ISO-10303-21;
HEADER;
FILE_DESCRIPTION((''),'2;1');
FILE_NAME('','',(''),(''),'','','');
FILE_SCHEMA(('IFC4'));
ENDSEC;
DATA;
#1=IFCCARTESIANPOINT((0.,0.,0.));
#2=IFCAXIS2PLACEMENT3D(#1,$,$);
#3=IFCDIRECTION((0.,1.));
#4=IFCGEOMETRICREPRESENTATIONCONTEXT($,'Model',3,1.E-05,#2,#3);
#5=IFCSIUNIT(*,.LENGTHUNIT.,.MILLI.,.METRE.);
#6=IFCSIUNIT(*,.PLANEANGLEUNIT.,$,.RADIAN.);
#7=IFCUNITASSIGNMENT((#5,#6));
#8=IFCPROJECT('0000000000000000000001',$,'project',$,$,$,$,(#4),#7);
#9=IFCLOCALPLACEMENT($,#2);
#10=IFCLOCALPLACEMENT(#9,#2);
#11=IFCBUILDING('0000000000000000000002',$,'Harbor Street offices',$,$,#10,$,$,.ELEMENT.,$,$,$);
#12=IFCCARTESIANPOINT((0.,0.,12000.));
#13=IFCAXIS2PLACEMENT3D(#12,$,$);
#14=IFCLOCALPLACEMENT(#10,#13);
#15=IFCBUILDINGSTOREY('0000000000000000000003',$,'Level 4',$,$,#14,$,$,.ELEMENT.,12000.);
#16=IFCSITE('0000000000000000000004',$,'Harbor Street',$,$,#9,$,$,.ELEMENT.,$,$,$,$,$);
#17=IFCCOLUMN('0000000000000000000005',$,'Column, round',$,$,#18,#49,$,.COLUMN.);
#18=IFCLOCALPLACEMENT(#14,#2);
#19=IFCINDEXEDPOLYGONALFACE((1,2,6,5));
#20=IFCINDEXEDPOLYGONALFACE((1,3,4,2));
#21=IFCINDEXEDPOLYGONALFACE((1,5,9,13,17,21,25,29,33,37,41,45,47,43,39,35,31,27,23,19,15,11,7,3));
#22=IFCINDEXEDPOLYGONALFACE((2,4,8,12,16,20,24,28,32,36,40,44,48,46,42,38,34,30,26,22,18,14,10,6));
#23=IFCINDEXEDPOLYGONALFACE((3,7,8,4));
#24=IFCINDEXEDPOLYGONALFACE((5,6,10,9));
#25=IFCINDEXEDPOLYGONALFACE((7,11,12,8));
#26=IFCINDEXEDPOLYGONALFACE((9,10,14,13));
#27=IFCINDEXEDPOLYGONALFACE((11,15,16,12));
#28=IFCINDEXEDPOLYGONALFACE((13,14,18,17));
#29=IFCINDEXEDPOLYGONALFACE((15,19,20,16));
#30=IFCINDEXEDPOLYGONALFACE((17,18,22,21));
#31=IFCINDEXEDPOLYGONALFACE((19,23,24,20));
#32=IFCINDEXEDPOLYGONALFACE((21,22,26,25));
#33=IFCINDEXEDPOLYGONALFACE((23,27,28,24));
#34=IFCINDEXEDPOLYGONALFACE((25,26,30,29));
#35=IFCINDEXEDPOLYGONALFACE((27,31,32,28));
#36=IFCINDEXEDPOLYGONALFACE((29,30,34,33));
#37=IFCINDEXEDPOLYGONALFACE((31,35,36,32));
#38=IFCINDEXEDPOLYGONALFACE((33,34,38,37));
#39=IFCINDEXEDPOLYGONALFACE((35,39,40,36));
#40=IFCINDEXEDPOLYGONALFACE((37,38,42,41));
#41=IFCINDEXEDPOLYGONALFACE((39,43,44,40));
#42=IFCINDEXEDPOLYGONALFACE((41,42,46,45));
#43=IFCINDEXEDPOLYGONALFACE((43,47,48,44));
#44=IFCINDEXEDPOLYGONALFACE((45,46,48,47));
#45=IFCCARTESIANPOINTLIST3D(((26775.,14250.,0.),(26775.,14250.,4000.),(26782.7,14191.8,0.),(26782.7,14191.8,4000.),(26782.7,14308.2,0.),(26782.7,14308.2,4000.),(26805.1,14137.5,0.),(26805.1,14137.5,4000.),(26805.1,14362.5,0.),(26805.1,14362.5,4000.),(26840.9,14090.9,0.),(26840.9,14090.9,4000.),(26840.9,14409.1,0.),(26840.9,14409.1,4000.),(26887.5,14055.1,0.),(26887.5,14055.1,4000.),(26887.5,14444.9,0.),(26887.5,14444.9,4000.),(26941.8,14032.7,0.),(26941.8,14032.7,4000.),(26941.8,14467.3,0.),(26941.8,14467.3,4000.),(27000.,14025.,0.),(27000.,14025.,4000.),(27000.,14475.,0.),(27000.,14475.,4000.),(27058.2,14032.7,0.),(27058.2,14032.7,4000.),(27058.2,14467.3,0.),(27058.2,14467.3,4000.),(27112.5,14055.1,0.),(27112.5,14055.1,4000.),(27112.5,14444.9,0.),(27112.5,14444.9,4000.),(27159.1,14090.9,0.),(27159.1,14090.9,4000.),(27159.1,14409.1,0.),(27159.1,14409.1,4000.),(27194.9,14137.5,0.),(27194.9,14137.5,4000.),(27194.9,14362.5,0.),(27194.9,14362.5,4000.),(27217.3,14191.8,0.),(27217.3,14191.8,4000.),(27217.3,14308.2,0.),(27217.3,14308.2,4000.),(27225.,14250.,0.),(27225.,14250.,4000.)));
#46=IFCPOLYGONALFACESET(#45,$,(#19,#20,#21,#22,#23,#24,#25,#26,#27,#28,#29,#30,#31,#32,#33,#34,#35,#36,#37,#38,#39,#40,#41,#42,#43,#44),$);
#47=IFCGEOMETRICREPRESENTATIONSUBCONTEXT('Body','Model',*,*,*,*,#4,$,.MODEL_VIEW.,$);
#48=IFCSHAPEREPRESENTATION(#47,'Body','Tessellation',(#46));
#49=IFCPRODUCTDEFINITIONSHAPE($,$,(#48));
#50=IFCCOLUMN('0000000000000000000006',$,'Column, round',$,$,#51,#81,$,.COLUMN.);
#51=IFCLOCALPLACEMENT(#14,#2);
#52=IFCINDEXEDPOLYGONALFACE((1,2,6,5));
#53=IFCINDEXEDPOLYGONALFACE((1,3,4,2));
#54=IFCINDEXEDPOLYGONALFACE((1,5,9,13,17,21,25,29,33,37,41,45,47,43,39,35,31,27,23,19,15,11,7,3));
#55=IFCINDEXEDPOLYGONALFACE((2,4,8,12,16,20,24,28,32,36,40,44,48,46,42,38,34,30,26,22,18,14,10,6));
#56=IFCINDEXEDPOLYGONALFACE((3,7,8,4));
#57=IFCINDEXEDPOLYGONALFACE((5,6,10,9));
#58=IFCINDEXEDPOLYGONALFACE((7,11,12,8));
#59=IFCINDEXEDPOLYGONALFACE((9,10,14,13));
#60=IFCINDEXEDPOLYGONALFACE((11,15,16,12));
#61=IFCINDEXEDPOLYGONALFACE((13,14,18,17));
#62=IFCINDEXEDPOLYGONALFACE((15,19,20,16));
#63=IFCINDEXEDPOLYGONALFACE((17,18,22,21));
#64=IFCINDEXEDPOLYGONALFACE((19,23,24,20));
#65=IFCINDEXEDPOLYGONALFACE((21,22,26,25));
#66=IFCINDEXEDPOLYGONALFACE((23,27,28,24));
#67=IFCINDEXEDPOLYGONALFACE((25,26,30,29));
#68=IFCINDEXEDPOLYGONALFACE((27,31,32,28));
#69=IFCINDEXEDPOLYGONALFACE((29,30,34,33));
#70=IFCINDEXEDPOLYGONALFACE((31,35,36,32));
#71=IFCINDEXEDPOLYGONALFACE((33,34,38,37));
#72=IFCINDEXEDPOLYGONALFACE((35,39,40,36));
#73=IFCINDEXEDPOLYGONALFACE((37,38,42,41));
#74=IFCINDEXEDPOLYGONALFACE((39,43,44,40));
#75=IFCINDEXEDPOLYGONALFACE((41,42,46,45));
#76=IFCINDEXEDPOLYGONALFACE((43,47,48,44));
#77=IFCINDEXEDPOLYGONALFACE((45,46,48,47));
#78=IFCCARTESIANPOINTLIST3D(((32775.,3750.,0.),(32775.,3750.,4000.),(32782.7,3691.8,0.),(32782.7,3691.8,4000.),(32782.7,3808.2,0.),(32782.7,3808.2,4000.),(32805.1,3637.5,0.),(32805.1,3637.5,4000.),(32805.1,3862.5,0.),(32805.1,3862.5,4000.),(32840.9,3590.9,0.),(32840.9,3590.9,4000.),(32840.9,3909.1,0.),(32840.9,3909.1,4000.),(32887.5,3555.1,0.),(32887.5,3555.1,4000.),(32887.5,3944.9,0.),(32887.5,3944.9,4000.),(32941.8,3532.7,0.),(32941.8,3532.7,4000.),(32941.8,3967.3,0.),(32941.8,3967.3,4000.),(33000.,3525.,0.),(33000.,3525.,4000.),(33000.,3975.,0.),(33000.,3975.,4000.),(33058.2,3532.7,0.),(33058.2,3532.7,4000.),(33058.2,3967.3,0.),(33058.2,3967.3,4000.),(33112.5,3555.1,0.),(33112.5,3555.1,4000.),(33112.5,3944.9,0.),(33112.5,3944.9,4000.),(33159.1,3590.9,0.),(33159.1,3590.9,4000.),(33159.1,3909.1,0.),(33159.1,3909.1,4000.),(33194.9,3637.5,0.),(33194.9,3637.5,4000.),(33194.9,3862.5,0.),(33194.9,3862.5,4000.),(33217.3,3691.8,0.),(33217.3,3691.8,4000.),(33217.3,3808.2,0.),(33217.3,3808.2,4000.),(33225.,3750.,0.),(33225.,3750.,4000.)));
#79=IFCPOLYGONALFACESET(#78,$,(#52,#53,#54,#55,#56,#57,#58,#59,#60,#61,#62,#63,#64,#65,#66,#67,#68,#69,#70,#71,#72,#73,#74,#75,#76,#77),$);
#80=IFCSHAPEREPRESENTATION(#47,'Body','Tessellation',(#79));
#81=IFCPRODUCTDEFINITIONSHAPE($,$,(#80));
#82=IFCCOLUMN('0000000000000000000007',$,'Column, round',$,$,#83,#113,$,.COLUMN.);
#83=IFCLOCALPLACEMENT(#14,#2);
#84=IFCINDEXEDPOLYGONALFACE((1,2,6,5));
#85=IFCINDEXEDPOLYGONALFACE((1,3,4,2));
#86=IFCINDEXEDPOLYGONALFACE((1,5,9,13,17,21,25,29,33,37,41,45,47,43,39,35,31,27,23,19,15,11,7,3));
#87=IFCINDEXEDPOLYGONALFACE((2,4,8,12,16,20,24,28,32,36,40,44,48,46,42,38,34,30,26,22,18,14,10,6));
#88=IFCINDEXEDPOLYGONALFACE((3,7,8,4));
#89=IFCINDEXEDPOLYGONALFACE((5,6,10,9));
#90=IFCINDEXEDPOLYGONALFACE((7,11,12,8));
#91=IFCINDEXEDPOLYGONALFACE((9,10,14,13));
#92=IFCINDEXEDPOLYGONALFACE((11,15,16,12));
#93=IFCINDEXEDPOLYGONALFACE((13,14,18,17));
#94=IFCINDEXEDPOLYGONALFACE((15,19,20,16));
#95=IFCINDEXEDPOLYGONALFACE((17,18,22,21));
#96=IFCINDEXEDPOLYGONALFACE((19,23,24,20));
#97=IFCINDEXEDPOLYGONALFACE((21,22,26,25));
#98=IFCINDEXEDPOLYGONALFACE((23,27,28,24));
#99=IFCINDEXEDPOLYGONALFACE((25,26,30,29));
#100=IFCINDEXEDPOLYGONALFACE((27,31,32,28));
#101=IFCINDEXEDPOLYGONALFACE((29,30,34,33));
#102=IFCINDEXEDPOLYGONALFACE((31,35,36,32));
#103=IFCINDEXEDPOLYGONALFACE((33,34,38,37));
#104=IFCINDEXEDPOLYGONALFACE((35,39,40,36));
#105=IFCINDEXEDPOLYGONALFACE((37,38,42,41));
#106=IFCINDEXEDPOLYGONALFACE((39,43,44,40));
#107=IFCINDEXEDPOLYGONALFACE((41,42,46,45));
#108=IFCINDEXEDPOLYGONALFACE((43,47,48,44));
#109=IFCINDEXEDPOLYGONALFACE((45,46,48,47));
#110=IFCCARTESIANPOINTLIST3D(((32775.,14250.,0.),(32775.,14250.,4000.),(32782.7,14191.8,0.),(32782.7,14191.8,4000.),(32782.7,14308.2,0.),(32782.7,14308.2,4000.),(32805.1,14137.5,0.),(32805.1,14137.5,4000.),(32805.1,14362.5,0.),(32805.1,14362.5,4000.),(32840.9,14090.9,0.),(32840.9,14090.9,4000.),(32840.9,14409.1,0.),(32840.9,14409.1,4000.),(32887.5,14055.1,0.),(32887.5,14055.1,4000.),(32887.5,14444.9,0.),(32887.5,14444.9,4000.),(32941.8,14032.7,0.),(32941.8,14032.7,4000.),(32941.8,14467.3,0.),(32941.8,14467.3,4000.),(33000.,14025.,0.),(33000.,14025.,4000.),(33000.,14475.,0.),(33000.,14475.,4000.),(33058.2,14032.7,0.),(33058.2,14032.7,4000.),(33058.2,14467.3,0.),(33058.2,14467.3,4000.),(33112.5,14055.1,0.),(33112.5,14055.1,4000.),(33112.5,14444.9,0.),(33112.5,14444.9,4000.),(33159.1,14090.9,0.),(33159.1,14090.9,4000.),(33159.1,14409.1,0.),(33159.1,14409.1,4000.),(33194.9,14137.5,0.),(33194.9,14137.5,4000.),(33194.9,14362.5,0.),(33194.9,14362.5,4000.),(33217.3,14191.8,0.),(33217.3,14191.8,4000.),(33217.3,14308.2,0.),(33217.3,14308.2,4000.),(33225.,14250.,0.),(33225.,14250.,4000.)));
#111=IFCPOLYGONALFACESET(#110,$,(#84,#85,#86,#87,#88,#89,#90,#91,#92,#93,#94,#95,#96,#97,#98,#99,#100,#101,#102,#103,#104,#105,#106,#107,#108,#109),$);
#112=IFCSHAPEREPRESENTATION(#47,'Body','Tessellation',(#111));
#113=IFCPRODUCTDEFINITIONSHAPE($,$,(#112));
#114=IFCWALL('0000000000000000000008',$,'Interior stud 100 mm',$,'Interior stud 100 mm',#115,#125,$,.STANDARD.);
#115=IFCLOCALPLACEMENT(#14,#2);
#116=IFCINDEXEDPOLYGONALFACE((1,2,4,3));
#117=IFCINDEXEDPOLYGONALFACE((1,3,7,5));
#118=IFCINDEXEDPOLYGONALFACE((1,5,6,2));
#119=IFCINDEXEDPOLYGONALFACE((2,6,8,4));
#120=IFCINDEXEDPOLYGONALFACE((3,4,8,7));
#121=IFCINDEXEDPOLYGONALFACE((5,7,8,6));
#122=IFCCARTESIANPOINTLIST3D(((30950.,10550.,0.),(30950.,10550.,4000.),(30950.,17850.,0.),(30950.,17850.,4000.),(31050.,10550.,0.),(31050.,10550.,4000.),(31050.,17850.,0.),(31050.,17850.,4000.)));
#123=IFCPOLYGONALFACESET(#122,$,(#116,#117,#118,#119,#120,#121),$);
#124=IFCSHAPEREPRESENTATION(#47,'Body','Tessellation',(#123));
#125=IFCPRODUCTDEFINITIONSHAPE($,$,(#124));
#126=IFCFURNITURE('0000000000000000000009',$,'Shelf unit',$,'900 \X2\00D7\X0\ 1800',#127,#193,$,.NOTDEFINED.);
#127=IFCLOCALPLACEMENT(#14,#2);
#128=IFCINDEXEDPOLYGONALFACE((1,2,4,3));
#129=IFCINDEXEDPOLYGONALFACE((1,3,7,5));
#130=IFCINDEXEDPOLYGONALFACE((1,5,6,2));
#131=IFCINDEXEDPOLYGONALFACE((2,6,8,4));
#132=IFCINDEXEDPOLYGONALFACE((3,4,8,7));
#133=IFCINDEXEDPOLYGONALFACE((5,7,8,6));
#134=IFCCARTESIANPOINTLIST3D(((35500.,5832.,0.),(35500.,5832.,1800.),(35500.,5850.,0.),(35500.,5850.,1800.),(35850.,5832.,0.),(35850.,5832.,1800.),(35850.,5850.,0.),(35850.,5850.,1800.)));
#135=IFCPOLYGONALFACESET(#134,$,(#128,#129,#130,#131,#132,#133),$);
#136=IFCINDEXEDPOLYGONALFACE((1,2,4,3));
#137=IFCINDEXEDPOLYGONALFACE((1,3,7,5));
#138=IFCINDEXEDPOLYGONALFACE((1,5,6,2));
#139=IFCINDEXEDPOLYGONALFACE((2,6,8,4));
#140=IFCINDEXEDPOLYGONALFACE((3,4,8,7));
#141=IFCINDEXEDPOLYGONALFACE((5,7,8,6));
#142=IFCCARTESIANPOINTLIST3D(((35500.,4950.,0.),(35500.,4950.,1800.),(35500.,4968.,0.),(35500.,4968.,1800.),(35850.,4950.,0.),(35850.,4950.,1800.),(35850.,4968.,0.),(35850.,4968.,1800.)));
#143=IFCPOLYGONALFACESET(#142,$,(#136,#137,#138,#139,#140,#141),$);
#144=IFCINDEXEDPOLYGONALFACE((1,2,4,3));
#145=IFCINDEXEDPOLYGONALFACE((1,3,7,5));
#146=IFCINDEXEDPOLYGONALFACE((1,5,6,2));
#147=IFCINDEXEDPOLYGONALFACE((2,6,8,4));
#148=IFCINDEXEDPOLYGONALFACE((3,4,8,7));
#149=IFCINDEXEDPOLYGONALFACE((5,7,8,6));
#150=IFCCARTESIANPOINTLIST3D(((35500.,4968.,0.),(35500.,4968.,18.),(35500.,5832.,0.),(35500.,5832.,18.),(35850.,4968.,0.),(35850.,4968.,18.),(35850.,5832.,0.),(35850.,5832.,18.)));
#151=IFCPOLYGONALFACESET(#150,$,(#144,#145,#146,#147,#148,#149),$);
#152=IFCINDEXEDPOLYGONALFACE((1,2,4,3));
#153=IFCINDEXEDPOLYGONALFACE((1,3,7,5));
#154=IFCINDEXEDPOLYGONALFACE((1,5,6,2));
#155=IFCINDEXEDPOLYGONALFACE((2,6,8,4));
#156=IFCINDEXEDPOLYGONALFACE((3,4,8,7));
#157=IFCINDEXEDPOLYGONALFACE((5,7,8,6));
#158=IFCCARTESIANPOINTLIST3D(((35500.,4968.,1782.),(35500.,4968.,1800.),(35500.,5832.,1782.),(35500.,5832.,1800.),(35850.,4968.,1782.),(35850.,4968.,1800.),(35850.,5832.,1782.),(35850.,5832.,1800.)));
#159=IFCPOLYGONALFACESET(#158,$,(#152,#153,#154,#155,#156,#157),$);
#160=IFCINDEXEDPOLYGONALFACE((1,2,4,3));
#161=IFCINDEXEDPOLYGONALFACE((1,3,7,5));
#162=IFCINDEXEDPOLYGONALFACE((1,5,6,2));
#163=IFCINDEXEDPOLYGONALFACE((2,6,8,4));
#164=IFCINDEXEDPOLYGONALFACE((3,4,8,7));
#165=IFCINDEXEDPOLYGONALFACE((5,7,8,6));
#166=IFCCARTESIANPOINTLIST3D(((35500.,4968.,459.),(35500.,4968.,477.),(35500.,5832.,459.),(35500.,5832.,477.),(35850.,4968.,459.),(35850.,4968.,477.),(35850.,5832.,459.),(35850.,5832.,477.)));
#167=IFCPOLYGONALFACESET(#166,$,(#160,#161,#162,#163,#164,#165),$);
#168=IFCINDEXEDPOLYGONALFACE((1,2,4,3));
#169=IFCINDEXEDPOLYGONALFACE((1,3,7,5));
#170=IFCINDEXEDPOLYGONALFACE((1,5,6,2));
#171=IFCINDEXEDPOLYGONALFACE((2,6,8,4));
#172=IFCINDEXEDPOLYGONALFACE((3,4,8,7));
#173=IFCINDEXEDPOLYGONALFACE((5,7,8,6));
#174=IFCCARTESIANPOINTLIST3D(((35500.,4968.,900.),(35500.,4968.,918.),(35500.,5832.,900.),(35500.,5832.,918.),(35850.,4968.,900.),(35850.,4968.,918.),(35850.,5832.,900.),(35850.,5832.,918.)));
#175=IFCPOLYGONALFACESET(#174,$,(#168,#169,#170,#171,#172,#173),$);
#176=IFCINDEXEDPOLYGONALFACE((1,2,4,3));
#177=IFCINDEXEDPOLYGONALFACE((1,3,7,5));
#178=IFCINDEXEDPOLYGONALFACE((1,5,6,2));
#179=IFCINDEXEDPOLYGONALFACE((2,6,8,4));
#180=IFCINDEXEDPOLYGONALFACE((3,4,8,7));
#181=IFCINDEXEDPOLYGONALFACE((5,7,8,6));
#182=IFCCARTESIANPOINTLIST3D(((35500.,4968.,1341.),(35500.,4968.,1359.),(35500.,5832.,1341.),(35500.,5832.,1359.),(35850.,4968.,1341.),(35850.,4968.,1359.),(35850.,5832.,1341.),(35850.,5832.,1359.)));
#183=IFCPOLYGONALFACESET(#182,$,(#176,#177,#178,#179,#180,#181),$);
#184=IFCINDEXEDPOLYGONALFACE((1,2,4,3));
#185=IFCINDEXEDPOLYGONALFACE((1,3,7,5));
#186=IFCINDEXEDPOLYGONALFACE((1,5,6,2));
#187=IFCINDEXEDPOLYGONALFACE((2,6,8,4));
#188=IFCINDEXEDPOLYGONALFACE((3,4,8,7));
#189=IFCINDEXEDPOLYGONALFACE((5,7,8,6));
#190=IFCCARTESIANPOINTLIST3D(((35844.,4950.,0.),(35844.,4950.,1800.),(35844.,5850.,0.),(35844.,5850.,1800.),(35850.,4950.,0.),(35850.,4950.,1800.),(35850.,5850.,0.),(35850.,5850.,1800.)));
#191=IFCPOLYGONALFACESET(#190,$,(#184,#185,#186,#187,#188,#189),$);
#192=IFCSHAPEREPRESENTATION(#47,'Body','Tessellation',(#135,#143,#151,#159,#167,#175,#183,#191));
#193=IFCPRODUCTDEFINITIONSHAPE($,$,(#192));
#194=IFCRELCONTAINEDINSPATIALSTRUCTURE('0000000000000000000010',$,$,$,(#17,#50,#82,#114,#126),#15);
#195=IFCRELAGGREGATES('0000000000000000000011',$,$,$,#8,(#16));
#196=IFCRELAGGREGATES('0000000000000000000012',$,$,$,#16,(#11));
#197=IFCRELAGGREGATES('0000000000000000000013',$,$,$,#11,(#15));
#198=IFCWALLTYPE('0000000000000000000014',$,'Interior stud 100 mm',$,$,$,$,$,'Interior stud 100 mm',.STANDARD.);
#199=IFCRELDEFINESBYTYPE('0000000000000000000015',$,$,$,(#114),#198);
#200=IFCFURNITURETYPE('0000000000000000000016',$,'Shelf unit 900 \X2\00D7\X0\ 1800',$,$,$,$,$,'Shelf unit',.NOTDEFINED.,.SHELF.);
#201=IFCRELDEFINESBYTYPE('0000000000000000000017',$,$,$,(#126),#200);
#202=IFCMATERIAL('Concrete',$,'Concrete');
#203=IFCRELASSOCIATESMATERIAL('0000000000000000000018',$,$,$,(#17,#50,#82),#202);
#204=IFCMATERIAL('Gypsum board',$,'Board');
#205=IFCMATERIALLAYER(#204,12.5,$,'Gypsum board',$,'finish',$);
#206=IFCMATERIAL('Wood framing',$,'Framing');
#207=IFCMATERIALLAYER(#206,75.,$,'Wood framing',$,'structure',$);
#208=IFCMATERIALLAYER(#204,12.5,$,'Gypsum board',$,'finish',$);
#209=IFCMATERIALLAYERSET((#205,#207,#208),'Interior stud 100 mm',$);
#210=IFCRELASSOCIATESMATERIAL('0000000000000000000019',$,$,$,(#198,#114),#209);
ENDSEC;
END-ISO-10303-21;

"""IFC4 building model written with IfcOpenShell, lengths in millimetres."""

from ifc_helpers import new_model, si_unit, direction, frame, origin, origin_2d, place, context, subcontext, project, spatial, polyline, circle, outline, extrude, source, transform, mapped, material, layer, layer_set, layer_usage, type_object, type_shapes, element, save


model = new_model("IFC4")

# Units and contexts
model_context = context("Model", 3, precision=1e-05, world=origin(), true_north=direction((0.0, 1.0)))
body_context = subcontext(model_context, "Body", "Model", "MODEL_VIEW")
ifc_project = project(units=[si_unit("LENGTHUNIT", "METRE", prefix="MILLI"), si_unit("PLANEANGLEUNIT", "RADIAN")], contexts=[model_context])

# Site, building, storey
site_placement = place(None, origin())
site = spatial("IfcSite", under=ifc_project, at=site_placement, Name="Harbor Street", CompositionType="ELEMENT")
building_placement = place(site_placement, origin())
building = spatial("IfcBuilding", under=site, at=building_placement, Name="Harbor Street offices", CompositionType="ELEMENT")
storey_placement = place(building_placement, frame((0.0, 0.0, 12000.0)))
storey = spatial("IfcBuildingStorey", under=building, at=storey_placement, Name="Level 4", CompositionType="ELEMENT", Elevation=12000.0)

# Columns
ifc_material_1 = material(Name="Concrete", Category="Concrete")
for number, where, z_axis, x_axis, name in (
    (1, (27000.0, 14250.0, 0.0), (0.0, 0.0, 1.0), (1.0, 0.0, 0.0), "Column, round"),
    (2, (33000.0, 3750.0, 0.0), (0.0, 0.0, 1.0), (1.0, 0.0, 0.0), "Column, round"),
    (3, (33000.0, 14250.0, 0.0), (0.0, 0.0, 1.0), (1.0, 0.0, 0.0), "Column, round"),
):
    element("IfcColumn", number, at=place(storey_placement, frame(where, z_axis=z_axis, x_axis=x_axis)), inside=storey, material=ifc_material_1, Name=name, PredefinedType="COLUMN", context=body_context, shape_type="SweptSolid", body=[
        extrude(circle(Radius=225.0, at=origin_2d()), origin(), (0.0, 0.0, 1.0), 4000.0),
    ])

# Wall
ifc_material_2 = material(Name="Gypsum board", Category="Board")
ifc_layer_1 = layer(ifc_material_2, 12.5, Name="Gypsum board", Category="finish")
ifc_material_3 = material(Name="Wood framing", Category="Framing")
ifc_layer_2 = layer(ifc_material_3, 75.0, Name="Wood framing", Category="structure")
ifc_layer_3 = layer(ifc_material_2, 12.5, Name="Gypsum board", Category="finish")
ifc_layer_set_1 = layer_set([ifc_layer_1, ifc_layer_2, ifc_layer_3], Name="Interior stud 100 mm")
ifc_layer_usage_1 = layer_usage(ifc_layer_set_1, "AXIS2", "NEGATIVE", 50.0)
wall_type_1 = type_object("IfcWallType", Name="Interior stud 100 mm", ElementType="Interior stud 100 mm", PredefinedType="STANDARD", material=ifc_layer_set_1)
wall_1_placement = place(storey_placement, frame((31000.0, 10500.0, 0.0), z_axis=(0.0, 0.0, 1.0), x_axis=(0.0, 1.0, 0.0)))
element("IfcWall", 4, at=wall_1_placement, inside=storey, type_object=wall_type_1, material=ifc_layer_usage_1, Name="Interior stud 100 mm", ObjectType="Interior stud 100 mm", PredefinedType="STANDARD", context=body_context, shape_type="SweptSolid", body=[
    extrude(outline(polyline([(50.0, -50.0), (7350.0, -50.0), (7350.0, 50.0), (50.0, 50.0), (50.0, -50.0)])), origin(), (0.0, 0.0, 1.0), 4000.0),
])

# Furniture
furniture_type_1 = type_object("IfcFurnitureType", Name="Shelf unit 900 × 1800", ElementType="Shelf unit", AssemblyPlace="NOTDEFINED", PredefinedType="SHELF")
shared_shape_1 = source(origin(), body_context, "Body", "SweptSolid", [
    extrude(outline(polyline([(-450.0, 0.0), (-432.0, 0.0), (-432.0, 350.0), (-450.0, 350.0), (-450.0, 0.0)])), origin(), (0.0, 0.0, 1.0), 1800.0),
    extrude(outline(polyline([(432.0, 0.0), (450.0, 0.0), (450.0, 350.0), (432.0, 350.0), (432.0, 0.0)])), origin(), (0.0, 0.0, 1.0), 1800.0),
    extrude(outline(polyline([(-432.0, 0.0), (432.0, 0.0), (432.0, 350.0), (-432.0, 350.0), (-432.0, 0.0)])), origin(), (0.0, 0.0, 1.0), 18.0),
    extrude(outline(polyline([(-432.0, 0.0), (432.0, 0.0), (432.0, 350.0), (-432.0, 350.0), (-432.0, 0.0)])), frame((0.0, 0.0, 1782.0)), (0.0, 0.0, 1.0), 18.0),
    extrude(outline(polyline([(-432.0, 0.0), (432.0, 0.0), (432.0, 350.0), (-432.0, 350.0), (-432.0, 0.0)])), frame((0.0, 0.0, 459.0)), (0.0, 0.0, 1.0), 18.0),
    extrude(outline(polyline([(-432.0, 0.0), (432.0, 0.0), (432.0, 350.0), (-432.0, 350.0), (-432.0, 0.0)])), frame((0.0, 0.0, 900.0)), (0.0, 0.0, 1.0), 18.0),
    extrude(outline(polyline([(-432.0, 0.0), (432.0, 0.0), (432.0, 350.0), (-432.0, 350.0), (-432.0, 0.0)])), frame((0.0, 0.0, 1341.0)), (0.0, 0.0, 1.0), 18.0),
    extrude(outline(polyline([(-450.0, 344.0), (450.0, 344.0), (450.0, 350.0), (-450.0, 350.0), (-450.0, 344.0)])), origin(), (0.0, 0.0, 1.0), 1800.0),
])
type_shapes(furniture_type_1, [shared_shape_1])
furniture_placement = place(storey_placement, frame((35500.0, 5400.0, 0.0), z_axis=(0.0, 0.0, 1.0), x_axis=(0.0, -1.0, 0.0)))
element("IfcFurniture", 5, at=furniture_placement, inside=storey, type_object=furniture_type_1, Name="Shelf unit", ObjectType="900 × 1800", PredefinedType="NOTDEFINED", context=body_context, shape_type="MappedRepresentation", body=[
    mapped(shared_shape_1, transform((0.0, 0.0, 0.0))),
])

save(model, "model.ifc")
